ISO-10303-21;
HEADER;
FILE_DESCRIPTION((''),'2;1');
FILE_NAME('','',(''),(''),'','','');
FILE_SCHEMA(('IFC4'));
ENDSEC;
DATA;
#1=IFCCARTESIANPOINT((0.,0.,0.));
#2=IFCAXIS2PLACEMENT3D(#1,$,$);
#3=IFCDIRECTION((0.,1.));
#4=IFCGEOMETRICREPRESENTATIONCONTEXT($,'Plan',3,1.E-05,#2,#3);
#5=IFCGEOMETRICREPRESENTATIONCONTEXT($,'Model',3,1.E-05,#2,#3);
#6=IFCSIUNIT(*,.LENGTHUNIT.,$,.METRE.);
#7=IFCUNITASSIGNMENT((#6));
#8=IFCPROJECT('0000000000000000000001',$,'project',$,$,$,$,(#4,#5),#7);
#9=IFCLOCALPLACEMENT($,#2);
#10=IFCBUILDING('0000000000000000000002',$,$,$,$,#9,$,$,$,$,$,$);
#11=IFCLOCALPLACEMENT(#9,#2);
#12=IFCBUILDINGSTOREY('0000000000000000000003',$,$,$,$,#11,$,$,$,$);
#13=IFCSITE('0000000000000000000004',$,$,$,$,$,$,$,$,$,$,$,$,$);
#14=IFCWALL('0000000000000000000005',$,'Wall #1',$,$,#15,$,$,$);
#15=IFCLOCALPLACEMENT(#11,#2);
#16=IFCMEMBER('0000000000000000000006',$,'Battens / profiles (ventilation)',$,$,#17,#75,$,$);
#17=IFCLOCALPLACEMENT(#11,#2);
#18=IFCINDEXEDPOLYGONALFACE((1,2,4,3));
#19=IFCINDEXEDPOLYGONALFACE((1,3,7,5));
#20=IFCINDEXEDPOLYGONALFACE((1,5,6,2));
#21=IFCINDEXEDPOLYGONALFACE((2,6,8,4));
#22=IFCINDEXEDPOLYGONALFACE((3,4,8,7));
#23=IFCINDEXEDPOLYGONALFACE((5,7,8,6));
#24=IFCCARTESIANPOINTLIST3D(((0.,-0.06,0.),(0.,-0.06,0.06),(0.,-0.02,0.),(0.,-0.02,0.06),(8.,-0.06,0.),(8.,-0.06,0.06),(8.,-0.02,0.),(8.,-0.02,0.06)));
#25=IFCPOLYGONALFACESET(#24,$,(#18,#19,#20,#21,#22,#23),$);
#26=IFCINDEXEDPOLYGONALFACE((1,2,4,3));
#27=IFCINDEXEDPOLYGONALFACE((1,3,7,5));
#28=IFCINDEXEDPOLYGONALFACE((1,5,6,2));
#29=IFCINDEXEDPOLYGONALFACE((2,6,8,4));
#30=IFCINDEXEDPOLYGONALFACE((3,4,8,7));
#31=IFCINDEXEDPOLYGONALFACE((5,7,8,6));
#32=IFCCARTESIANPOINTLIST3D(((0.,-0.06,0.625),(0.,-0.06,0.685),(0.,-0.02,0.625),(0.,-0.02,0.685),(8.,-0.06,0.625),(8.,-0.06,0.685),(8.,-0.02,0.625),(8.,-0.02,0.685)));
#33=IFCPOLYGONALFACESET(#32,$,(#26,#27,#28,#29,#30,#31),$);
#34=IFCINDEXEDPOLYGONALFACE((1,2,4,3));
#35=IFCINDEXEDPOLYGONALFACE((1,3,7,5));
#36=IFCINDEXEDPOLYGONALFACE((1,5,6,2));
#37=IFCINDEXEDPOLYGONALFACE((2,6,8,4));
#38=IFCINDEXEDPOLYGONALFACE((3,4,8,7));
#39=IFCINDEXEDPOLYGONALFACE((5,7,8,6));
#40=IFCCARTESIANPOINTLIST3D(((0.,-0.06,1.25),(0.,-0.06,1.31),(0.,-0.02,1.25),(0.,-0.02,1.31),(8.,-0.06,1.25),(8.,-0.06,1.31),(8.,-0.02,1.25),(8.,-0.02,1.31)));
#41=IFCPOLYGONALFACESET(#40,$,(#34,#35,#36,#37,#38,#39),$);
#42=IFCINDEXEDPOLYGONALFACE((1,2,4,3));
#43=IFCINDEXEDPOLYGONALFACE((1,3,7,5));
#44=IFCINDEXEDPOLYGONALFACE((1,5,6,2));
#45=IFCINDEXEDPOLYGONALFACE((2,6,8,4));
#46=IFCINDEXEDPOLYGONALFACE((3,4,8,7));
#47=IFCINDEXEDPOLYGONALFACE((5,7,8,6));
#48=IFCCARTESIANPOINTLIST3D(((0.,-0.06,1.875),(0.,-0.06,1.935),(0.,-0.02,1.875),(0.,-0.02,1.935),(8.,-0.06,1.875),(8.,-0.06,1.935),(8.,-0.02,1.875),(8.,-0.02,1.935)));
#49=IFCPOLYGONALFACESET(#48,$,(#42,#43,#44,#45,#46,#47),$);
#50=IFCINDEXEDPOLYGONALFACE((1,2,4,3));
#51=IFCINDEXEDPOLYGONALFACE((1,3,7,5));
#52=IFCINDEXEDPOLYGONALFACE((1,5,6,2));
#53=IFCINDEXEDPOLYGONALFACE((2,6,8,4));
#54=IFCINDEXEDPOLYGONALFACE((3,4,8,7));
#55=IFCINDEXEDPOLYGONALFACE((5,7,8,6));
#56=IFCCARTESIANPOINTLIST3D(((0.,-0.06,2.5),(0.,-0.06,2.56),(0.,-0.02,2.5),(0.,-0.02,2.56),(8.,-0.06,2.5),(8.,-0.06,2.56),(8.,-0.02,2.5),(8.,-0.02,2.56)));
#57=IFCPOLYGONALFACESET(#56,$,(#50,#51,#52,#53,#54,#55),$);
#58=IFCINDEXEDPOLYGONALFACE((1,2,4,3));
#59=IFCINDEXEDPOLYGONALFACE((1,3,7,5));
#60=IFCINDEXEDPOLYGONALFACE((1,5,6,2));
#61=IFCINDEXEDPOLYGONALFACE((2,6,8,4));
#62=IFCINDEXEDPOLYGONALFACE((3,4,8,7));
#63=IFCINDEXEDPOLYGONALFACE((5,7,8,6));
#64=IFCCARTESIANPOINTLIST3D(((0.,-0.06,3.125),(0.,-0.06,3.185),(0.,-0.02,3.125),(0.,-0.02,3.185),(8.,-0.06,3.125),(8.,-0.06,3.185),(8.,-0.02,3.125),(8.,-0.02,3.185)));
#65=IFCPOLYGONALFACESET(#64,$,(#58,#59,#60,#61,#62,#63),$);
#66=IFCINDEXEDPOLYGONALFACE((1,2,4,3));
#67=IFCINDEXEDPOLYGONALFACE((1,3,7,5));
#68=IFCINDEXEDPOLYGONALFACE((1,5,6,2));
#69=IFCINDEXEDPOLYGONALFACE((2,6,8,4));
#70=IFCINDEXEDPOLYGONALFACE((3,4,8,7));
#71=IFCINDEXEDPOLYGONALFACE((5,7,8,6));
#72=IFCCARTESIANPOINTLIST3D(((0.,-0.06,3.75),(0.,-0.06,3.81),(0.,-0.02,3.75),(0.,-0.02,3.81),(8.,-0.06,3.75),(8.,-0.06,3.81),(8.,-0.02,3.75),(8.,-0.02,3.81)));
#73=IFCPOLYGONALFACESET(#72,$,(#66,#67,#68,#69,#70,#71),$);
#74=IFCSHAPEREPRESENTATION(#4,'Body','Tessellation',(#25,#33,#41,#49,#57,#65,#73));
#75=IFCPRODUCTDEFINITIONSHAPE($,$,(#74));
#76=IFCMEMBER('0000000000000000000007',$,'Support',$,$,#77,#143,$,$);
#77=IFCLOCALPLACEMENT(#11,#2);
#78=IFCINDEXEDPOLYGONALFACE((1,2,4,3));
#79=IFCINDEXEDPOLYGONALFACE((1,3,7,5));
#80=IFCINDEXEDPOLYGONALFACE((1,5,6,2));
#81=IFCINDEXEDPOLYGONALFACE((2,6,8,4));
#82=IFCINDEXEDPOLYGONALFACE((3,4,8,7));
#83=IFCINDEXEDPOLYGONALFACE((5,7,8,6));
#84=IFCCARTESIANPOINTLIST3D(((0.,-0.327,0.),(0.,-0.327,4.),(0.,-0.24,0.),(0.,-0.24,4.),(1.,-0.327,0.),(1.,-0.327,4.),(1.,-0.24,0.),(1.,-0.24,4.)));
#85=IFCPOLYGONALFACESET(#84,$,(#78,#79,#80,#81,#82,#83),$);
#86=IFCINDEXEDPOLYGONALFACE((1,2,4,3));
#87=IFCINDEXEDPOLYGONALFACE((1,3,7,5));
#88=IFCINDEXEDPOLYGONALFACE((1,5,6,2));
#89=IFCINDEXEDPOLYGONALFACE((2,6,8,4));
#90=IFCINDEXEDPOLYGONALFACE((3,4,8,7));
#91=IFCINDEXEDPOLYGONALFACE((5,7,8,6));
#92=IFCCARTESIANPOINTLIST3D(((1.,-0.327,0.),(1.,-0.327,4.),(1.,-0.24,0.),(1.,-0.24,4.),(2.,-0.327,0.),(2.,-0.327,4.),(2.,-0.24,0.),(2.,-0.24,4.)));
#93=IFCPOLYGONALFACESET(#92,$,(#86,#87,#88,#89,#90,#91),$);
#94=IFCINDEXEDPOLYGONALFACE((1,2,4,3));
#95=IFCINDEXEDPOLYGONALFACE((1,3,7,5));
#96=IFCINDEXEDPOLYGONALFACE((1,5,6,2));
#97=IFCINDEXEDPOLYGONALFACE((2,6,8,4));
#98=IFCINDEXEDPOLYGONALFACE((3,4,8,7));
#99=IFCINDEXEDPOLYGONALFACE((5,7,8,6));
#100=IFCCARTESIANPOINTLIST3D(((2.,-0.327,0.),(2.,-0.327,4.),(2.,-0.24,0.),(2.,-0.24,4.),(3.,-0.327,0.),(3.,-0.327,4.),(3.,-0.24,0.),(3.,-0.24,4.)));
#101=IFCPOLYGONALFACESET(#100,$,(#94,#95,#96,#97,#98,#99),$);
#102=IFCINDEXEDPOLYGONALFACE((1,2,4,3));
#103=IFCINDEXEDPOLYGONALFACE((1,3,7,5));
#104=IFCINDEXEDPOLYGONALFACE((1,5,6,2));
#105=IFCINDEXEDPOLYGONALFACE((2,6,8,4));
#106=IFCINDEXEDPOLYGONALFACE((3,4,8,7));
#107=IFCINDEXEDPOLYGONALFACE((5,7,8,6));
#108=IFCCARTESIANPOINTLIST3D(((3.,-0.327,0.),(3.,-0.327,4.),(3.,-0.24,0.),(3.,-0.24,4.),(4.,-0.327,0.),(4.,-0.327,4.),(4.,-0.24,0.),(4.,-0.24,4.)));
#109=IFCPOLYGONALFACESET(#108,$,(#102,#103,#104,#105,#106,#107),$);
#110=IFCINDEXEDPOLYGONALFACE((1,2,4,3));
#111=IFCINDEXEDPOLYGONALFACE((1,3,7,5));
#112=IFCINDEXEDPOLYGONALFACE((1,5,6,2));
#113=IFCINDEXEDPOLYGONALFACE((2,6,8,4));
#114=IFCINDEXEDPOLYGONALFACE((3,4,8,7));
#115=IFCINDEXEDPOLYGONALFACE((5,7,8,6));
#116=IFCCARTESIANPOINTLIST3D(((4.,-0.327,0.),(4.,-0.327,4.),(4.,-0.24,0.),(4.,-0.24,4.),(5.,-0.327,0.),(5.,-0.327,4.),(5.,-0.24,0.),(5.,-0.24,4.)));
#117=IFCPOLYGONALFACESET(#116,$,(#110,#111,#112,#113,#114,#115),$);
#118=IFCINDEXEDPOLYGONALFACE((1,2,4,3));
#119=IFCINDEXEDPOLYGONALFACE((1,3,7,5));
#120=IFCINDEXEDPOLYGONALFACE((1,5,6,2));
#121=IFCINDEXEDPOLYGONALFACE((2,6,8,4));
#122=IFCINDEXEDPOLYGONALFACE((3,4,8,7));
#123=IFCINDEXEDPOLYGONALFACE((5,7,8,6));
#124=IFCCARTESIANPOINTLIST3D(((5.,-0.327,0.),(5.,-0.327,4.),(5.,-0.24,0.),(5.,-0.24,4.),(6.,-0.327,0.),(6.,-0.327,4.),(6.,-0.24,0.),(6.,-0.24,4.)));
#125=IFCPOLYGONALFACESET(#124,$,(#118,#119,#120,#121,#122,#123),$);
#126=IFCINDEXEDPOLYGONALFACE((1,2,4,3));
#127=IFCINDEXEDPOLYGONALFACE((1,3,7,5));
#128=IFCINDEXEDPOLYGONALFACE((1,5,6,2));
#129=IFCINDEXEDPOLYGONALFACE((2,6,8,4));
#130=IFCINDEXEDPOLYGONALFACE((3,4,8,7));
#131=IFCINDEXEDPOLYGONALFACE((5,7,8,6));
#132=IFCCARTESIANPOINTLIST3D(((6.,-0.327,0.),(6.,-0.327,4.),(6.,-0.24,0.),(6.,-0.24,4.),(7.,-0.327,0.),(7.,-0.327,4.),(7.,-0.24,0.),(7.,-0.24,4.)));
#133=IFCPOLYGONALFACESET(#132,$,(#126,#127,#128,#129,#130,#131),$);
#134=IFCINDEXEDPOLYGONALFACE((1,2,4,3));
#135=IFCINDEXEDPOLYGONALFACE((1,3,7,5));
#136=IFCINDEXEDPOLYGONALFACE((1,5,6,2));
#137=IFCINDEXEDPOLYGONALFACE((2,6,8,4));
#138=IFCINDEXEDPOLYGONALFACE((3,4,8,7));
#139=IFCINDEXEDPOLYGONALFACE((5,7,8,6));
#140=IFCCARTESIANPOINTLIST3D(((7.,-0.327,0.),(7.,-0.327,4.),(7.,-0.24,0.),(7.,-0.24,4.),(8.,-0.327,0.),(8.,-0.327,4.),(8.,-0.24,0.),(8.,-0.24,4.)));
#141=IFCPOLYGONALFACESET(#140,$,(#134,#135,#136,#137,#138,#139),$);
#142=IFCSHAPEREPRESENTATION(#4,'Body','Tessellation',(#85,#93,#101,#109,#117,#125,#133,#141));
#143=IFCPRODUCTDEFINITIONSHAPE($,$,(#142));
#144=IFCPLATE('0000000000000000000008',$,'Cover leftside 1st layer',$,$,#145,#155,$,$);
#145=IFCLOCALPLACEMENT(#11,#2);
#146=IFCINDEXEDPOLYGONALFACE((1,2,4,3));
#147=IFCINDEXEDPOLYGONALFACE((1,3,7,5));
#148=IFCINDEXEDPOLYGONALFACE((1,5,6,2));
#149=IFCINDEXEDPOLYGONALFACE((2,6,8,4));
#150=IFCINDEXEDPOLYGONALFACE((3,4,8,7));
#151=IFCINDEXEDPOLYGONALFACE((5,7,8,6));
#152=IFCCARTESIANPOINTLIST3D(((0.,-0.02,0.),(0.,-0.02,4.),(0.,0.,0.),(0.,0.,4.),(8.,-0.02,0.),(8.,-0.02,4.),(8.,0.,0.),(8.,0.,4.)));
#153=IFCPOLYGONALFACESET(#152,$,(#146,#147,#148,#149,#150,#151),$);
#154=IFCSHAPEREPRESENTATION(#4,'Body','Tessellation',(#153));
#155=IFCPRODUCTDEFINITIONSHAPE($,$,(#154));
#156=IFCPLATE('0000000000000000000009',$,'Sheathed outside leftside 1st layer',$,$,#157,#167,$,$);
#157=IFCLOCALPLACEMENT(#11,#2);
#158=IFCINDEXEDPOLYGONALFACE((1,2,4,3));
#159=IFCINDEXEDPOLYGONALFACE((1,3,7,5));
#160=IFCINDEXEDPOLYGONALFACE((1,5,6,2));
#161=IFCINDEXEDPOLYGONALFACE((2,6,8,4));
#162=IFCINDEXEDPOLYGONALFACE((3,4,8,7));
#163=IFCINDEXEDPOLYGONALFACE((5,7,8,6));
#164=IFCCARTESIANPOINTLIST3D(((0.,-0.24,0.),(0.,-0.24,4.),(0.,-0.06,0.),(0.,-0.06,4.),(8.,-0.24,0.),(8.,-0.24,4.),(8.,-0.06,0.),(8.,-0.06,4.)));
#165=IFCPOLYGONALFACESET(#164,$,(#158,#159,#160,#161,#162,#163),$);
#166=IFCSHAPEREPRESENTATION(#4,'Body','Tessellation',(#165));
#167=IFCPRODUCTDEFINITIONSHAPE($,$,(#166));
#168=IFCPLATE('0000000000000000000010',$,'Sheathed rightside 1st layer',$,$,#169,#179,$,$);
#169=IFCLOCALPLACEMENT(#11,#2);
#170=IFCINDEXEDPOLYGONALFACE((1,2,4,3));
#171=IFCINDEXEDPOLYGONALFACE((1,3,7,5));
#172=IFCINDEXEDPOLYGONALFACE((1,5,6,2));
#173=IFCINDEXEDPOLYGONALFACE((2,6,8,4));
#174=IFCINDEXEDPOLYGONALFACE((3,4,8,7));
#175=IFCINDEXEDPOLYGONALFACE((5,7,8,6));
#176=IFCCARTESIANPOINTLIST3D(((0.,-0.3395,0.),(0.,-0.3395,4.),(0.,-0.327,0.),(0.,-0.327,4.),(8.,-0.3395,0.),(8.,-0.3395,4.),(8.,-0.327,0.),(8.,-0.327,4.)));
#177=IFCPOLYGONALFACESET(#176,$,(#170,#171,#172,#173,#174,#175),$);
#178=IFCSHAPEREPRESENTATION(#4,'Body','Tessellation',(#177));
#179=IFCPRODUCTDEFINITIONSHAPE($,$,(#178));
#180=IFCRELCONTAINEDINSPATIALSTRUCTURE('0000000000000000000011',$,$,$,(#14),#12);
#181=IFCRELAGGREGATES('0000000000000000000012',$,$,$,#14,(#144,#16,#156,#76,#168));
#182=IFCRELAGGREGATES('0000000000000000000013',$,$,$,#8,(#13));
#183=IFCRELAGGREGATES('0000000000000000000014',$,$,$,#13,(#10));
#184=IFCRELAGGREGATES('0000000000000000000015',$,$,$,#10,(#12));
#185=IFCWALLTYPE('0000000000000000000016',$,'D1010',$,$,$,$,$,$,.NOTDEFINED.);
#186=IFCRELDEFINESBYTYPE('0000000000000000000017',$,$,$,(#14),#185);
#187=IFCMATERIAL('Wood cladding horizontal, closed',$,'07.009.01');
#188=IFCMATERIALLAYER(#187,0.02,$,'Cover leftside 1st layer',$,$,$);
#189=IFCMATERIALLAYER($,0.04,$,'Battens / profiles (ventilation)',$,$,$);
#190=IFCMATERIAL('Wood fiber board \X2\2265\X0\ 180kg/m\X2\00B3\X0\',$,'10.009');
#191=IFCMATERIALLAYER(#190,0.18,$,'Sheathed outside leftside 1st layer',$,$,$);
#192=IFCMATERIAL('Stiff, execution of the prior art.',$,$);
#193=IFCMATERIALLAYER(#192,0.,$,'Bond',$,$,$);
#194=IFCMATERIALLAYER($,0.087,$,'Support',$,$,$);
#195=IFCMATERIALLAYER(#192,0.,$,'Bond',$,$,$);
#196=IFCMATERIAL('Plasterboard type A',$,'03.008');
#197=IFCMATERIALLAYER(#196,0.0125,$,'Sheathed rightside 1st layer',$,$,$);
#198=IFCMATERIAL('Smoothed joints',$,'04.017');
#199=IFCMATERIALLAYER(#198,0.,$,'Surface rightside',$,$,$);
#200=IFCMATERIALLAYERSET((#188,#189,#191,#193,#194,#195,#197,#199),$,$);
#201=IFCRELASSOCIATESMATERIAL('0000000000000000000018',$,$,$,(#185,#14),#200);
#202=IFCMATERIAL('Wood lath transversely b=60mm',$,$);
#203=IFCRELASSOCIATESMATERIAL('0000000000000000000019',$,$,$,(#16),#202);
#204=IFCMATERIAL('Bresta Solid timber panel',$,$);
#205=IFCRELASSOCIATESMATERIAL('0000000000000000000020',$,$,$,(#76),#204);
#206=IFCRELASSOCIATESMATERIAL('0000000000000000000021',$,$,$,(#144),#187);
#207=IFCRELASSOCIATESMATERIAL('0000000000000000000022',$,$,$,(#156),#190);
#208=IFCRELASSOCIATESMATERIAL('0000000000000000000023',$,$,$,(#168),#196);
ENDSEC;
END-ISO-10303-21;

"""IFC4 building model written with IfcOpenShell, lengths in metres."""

from ifc_helpers import new_model, si_unit, direction, frame, frame_2d, origin, origin_with_axes, place, context, project, spatial, rectangle, extrude, material, layer, layer_set, type_object, element, aggregate, save


model = new_model("IFC4")

# Units and contexts
plan_context = context("Plan", 3, precision=1e-05, world=origin(), true_north=direction((0.0, 1.0)))
model_context = context("Model", 3, precision=1e-05, world=origin(), true_north=direction((0.0, 1.0)))
ifc_project = project(units=[si_unit("LENGTHUNIT", "METRE")], contexts=[plan_context, model_context])

# Site, building, storey
site = spatial("IfcSite", under=ifc_project)
building_placement = place(None, origin())
building = spatial("IfcBuilding", under=site, at=building_placement)
storey_placement = place(building_placement, origin())
storey = spatial("IfcBuildingStorey", under=building, at=storey_placement)

# Wall, members, plates
ifc_material_1 = material(Name="Wood cladding horizontal, closed", Category="07.009.01")
ifc_layer_1 = layer(ifc_material_1, 0.02, Name="Cover leftside 1st layer")
ifc_layer_2 = layer(None, 0.04, Name="Battens / profiles (ventilation)")
ifc_material_2 = material(Name="Wood fiber board ≥ 180kg/m³", Category="10.009")
ifc_layer_3 = layer(ifc_material_2, 0.18, Name="Sheathed outside leftside 1st layer")
ifc_material_3 = material(Name="Stiff, execution of the prior art.")
ifc_layer_4 = layer(ifc_material_3, 0.0, Name="Bond")
ifc_layer_5 = layer(None, 0.087, Name="Support")
ifc_layer_6 = layer(ifc_material_3, 0.0, Name="Bond")
ifc_material_4 = material(Name="Plasterboard type A", Category="03.008")
ifc_layer_7 = layer(ifc_material_4, 0.0125, Name="Sheathed rightside 1st layer")
ifc_material_5 = material(Name="Smoothed joints", Category="04.017")
ifc_layer_8 = layer(ifc_material_5, 0.0, Name="Surface rightside")
ifc_layer_set = layer_set([ifc_layer_1, ifc_layer_2, ifc_layer_3, ifc_layer_4, ifc_layer_5, ifc_layer_6, ifc_layer_7, ifc_layer_8])
wall_type = type_object("IfcWallType", Name="D1010", PredefinedType="NOTDEFINED", material=ifc_layer_set)
wall_placement = place(None, frame((0.0, 0.0, 0.0), z_axis=(0.0, -1.0, 0.0), x_axis=(1.0, 0.0, 0.0)))
wall = element("IfcWall", 1, at=wall_placement, inside=storey, type_object=wall_type, material=ifc_layer_set, Name="Wall #1")
ifc_material_6 = material(Name="Wood lath transversely b=60mm")
member_1_placement = place(wall_placement, origin())
member_1 = element("IfcMember", 2, at=member_1_placement, material=ifc_material_6, Name="Battens / profiles (ventilation)", context=plan_context, shape_type="SweptSolid", body=[
    extrude(rectangle(XDim=0.06, YDim=0.04, at=frame_2d((0.03, 0.02), x_axis=(1.0, 0.0))), frame((0.0, 0.0, 0.02), z_axis=(1.0, 0.0, 0.0), x_axis=(0.0, 1.0, 0.0)), (0.0, 0.0, 1.0), 8.0),
    extrude(rectangle(XDim=0.06, YDim=0.04, at=frame_2d((0.03, 0.02), x_axis=(1.0, 0.0))), frame((0.0, 0.625, 0.02), z_axis=(1.0, 0.0, 0.0), x_axis=(0.0, 1.0, 0.0)), (0.0, 0.0, 1.0), 8.0),
    extrude(rectangle(XDim=0.06, YDim=0.04, at=frame_2d((0.03, 0.02), x_axis=(1.0, 0.0))), frame((0.0, 1.25, 0.02), z_axis=(1.0, 0.0, 0.0), x_axis=(0.0, 1.0, 0.0)), (0.0, 0.0, 1.0), 8.0),
    extrude(rectangle(XDim=0.06, YDim=0.04, at=frame_2d((0.03, 0.02), x_axis=(1.0, 0.0))), frame((0.0, 1.875, 0.02), z_axis=(1.0, 0.0, 0.0), x_axis=(0.0, 1.0, 0.0)), (0.0, 0.0, 1.0), 8.0),
    extrude(rectangle(XDim=0.06, YDim=0.04, at=frame_2d((0.03, 0.02), x_axis=(1.0, 0.0))), frame((0.0, 2.5, 0.02), z_axis=(1.0, 0.0, 0.0), x_axis=(0.0, 1.0, 0.0)), (0.0, 0.0, 1.0), 8.0),
    extrude(rectangle(XDim=0.06, YDim=0.04, at=frame_2d((0.03, 0.02), x_axis=(1.0, 0.0))), frame((0.0, 3.125, 0.02), z_axis=(1.0, 0.0, 0.0), x_axis=(0.0, 1.0, 0.0)), (0.0, 0.0, 1.0), 8.0),
    extrude(rectangle(XDim=0.06, YDim=0.04, at=frame_2d((0.03, 0.02), x_axis=(1.0, 0.0))), frame((0.0, 3.75, 0.02), z_axis=(1.0, 0.0, 0.0), x_axis=(0.0, 1.0, 0.0)), (0.0, 0.0, 1.0), 8.0),
])
ifc_material_7 = material(Name="Bresta Solid timber panel")
member_2_placement = place(wall_placement, origin())
member_2 = element("IfcMember", 3, at=member_2_placement, material=ifc_material_7, Name="Support", context=plan_context, shape_type="SweptSolid", body=[
    extrude(rectangle(XDim=1.0, YDim=0.087, at=frame_2d((0.5, 0.0435), x_axis=(1.0, 0.0))), frame((0.0, 4.0, 0.24), z_axis=(0.0, -1.0, 0.0), x_axis=(1.0, 0.0, 0.0)), (0.0, 0.0, 1.0), 4.0),
    extrude(rectangle(XDim=1.0, YDim=0.087, at=frame_2d((0.5, 0.0435), x_axis=(1.0, 0.0))), frame((1.0, 4.0, 0.24), z_axis=(0.0, -1.0, 0.0), x_axis=(1.0, 0.0, 0.0)), (0.0, 0.0, 1.0), 4.0),
    extrude(rectangle(XDim=1.0, YDim=0.087, at=frame_2d((0.5, 0.0435), x_axis=(1.0, 0.0))), frame((2.0, 4.0, 0.24), z_axis=(0.0, -1.0, 0.0), x_axis=(1.0, 0.0, 0.0)), (0.0, 0.0, 1.0), 4.0),
    extrude(rectangle(XDim=1.0, YDim=0.087, at=frame_2d((0.5, 0.0435), x_axis=(1.0, 0.0))), frame((3.0, 4.0, 0.24), z_axis=(0.0, -1.0, 0.0), x_axis=(1.0, 0.0, 0.0)), (0.0, 0.0, 1.0), 4.0),
    extrude(rectangle(XDim=1.0, YDim=0.087, at=frame_2d((0.5, 0.0435), x_axis=(1.0, 0.0))), frame((4.0, 4.0, 0.24), z_axis=(0.0, -1.0, 0.0), x_axis=(1.0, 0.0, 0.0)), (0.0, 0.0, 1.0), 4.0),
    extrude(rectangle(XDim=1.0, YDim=0.087, at=frame_2d((0.5, 0.0435), x_axis=(1.0, 0.0))), frame((5.0, 4.0, 0.24), z_axis=(0.0, -1.0, 0.0), x_axis=(1.0, 0.0, 0.0)), (0.0, 0.0, 1.0), 4.0),
    extrude(rectangle(XDim=1.0, YDim=0.087, at=frame_2d((0.5, 0.0435), x_axis=(1.0, 0.0))), frame((6.0, 4.0, 0.24), z_axis=(0.0, -1.0, 0.0), x_axis=(1.0, 0.0, 0.0)), (0.0, 0.0, 1.0), 4.0),
    extrude(rectangle(XDim=1.0, YDim=0.087, at=frame_2d((0.5, 0.0435), x_axis=(1.0, 0.0))), frame((7.0, 4.0, 0.24), z_axis=(0.0, -1.0, 0.0), x_axis=(1.0, 0.0, 0.0)), (0.0, 0.0, 1.0), 4.0),
])
plate_1_placement = place(wall_placement, origin())
plate_1 = element("IfcPlate", 4, at=plate_1_placement, material=ifc_material_1, Name="Cover leftside 1st layer", context=plan_context, shape_type="SweptSolid", body=[
    extrude(rectangle(XDim=8.0, YDim=4.0, at=frame_2d((4.0, 2.0), x_axis=(1.0, 0.0))), origin_with_axes(), (0.0, 0.0, 1.0), 0.02),
])
plate_2_placement = place(wall_placement, origin())
plate_2 = element("IfcPlate", 5, at=plate_2_placement, material=ifc_material_2, Name="Sheathed outside leftside 1st layer", context=plan_context, shape_type="SweptSolid", body=[
    extrude(rectangle(XDim=8.0, YDim=4.0, at=frame_2d((4.0, 2.0), x_axis=(1.0, 0.0))), frame((0.0, 0.0, 0.06), z_axis=(0.0, 0.0, 1.0), x_axis=(1.0, 0.0, 0.0)), (0.0, 0.0, 1.0), 0.18),
])
plate_3_placement = place(wall_placement, origin())
plate_3 = element("IfcPlate", 6, at=plate_3_placement, material=ifc_material_4, Name="Sheathed rightside 1st layer", context=plan_context, shape_type="SweptSolid", body=[
    extrude(rectangle(XDim=8.0, YDim=4.0, at=frame_2d((4.0, 2.0), x_axis=(1.0, 0.0))), frame((0.0, 0.0, 0.327), z_axis=(0.0, 0.0, 1.0), x_axis=(1.0, 0.0, 0.0)), (0.0, 0.0, 1.0), 0.0125),
])
aggregate(wall, [plate_1, member_1, plate_2, member_2, plate_3])

save(model, "model.ifc")
